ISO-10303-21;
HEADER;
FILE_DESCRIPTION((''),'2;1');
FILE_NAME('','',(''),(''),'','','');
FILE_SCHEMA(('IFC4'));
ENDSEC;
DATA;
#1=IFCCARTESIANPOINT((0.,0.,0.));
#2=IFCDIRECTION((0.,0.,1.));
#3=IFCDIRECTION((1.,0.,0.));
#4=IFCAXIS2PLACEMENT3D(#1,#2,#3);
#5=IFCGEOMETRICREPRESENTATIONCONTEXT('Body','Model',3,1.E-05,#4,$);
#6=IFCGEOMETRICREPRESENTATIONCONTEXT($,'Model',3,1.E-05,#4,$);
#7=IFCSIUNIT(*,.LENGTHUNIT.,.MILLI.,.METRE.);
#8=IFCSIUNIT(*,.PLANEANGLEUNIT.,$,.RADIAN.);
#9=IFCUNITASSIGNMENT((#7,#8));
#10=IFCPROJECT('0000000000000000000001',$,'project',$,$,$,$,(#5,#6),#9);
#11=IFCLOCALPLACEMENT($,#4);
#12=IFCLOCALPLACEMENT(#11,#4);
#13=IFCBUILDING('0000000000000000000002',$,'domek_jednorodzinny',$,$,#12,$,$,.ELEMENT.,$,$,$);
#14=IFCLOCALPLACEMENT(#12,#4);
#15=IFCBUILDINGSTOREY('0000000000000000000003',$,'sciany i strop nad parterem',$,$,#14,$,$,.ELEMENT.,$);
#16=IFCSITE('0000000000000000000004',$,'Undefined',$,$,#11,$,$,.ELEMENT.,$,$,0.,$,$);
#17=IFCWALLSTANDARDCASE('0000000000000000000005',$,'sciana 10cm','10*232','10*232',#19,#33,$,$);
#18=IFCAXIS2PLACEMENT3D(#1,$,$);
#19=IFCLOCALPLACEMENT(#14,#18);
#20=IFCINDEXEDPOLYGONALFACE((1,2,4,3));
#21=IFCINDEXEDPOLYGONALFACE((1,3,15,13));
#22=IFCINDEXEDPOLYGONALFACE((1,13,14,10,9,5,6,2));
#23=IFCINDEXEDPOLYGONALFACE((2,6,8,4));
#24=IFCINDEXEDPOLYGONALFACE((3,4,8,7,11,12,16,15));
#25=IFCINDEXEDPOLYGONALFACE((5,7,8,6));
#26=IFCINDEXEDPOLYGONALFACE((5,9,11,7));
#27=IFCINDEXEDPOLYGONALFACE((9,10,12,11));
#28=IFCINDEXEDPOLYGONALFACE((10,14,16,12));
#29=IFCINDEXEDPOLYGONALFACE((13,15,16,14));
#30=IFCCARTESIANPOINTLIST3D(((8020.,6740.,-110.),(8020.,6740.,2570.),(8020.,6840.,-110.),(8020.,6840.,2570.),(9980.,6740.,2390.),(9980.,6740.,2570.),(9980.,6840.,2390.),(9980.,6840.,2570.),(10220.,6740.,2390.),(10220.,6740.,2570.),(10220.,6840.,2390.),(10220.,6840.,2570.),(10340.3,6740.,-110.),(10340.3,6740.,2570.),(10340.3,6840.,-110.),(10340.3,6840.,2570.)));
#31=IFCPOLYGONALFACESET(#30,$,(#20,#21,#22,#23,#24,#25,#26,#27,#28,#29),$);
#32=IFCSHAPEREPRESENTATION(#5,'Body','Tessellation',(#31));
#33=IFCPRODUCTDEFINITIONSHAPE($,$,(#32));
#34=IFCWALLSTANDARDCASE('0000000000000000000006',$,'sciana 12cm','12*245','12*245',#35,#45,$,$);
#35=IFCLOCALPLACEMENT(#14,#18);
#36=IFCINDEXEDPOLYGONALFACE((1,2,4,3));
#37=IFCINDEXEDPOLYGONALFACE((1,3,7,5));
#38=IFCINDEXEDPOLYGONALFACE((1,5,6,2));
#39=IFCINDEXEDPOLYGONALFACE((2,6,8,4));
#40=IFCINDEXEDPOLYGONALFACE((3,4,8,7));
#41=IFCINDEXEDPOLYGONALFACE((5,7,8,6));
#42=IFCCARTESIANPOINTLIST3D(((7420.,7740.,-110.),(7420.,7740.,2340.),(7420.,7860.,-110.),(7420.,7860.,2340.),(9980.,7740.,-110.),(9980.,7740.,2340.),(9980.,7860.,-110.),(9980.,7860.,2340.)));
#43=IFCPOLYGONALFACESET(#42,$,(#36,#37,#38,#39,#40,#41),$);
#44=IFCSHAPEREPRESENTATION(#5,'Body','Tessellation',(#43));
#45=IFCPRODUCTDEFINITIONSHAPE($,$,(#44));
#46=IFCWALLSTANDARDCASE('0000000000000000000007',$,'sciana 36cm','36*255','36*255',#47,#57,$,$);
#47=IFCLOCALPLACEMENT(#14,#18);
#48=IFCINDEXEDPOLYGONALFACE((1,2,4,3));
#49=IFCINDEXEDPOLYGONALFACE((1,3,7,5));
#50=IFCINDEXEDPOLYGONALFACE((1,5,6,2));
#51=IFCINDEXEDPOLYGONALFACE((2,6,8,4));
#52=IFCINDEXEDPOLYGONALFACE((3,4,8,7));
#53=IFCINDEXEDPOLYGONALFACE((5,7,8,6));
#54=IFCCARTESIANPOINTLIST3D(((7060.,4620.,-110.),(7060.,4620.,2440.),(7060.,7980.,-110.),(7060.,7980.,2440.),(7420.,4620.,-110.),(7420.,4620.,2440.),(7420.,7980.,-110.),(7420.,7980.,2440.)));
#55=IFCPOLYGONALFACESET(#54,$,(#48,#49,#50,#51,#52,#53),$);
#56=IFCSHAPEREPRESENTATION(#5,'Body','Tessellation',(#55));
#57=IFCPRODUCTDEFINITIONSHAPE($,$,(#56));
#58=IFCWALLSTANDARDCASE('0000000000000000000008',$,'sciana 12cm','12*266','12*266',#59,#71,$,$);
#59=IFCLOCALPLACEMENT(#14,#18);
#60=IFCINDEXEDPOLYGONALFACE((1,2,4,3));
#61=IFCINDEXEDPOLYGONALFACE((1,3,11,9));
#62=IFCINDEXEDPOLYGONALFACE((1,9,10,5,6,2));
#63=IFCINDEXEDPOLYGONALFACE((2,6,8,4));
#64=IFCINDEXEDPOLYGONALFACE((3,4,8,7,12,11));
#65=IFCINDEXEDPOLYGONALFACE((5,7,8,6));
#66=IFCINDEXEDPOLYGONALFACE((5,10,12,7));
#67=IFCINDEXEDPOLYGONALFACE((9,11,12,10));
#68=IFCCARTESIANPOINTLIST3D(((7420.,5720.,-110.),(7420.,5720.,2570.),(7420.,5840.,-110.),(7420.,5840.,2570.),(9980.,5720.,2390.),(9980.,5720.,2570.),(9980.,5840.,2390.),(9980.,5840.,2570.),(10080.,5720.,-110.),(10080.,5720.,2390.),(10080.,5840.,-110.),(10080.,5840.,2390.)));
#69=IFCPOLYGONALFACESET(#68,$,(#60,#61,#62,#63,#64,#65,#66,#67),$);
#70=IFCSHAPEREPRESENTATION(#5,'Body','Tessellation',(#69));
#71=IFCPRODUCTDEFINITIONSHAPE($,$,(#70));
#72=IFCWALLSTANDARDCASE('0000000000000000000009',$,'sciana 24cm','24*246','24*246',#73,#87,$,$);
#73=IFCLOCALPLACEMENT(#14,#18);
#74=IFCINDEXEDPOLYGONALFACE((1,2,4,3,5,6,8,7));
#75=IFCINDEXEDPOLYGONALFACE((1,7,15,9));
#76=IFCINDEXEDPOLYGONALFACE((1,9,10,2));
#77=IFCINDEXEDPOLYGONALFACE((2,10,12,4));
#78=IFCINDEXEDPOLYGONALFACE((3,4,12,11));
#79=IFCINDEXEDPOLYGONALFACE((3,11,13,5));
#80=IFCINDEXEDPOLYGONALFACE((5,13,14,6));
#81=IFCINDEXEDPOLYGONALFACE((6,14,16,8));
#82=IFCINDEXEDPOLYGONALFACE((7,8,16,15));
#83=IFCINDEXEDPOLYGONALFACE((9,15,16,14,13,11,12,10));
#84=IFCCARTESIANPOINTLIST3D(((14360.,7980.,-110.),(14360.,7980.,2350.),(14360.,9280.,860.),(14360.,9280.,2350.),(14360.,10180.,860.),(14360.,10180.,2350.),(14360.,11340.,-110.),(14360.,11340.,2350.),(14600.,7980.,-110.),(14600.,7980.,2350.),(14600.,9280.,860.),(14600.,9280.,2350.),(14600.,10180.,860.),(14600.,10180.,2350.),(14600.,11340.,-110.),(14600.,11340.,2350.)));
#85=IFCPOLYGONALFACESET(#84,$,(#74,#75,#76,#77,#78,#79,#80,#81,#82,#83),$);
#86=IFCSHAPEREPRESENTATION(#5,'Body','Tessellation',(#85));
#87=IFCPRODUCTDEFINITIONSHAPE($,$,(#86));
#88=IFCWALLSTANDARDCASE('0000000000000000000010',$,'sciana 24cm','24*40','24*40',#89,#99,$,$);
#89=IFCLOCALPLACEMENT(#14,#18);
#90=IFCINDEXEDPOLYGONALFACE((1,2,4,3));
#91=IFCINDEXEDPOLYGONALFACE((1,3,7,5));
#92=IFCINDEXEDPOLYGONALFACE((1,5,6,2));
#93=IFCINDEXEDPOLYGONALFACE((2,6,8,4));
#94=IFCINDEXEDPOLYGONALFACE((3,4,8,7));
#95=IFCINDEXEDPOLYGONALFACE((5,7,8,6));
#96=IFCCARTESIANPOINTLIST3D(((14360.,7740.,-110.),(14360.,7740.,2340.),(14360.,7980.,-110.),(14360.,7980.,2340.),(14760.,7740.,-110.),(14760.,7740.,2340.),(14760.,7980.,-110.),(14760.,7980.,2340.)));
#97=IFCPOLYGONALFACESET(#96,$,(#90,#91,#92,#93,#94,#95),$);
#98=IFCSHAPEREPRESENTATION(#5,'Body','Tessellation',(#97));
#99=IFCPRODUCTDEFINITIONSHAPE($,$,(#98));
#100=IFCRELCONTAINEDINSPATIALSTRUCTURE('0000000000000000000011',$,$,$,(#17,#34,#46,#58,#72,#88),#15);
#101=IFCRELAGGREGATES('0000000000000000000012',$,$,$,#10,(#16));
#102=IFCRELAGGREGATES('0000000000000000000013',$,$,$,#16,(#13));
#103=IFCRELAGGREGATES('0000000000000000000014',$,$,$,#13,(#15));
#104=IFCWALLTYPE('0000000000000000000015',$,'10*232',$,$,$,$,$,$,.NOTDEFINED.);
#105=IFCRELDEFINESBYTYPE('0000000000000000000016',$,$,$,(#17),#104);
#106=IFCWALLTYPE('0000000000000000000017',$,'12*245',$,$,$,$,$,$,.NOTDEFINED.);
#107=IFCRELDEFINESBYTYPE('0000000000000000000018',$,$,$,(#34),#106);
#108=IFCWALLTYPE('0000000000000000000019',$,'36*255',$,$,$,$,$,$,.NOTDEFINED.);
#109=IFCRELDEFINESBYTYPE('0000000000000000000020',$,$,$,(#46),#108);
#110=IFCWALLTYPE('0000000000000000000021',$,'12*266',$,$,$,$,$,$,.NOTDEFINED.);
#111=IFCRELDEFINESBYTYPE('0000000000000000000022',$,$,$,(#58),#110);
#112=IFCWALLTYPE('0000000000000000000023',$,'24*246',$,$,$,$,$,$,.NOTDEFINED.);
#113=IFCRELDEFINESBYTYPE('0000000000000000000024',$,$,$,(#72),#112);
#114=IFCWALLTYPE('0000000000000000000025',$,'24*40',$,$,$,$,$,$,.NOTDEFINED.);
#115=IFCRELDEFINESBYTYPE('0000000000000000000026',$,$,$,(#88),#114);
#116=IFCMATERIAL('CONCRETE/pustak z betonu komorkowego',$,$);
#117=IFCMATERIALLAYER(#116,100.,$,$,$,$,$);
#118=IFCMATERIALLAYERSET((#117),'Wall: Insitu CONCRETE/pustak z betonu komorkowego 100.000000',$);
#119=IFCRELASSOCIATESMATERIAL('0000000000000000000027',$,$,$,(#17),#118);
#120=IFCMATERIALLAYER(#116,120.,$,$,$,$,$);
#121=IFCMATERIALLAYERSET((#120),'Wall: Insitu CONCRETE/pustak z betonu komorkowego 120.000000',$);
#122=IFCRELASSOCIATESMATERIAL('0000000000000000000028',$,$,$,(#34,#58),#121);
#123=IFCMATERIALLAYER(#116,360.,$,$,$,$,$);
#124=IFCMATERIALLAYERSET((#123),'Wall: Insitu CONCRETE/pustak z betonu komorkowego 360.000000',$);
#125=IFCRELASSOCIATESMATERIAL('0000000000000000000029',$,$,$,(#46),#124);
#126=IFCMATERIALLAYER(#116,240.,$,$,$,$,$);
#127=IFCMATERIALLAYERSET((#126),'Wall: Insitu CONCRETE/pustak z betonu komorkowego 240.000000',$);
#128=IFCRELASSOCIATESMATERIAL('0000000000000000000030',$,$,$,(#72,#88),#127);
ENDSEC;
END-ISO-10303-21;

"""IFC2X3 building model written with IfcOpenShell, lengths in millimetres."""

from ifc_helpers import new_model, si_unit, frame, frame_2d, origin_with_axes, place, context, project, spatial, polyline, rectangle, outline, extrude, material, layer, layer_set, layer_usage, type_object, element, save


model = new_model("IFC2X3")

# Units and contexts
model_context_1 = context("Model", 3, precision=1e-05, world=origin_with_axes(), identifier="Body")
model_context_2 = context("Model", 3, precision=1e-05, world=origin_with_axes())
ifc_project = project(units=[si_unit("LENGTHUNIT", "METRE", prefix="MILLI"), si_unit("PLANEANGLEUNIT", "RADIAN")], contexts=[model_context_1, model_context_2])

# Site, building, storey
site_placement = place(None, origin_with_axes())
site = spatial("IfcSite", under=ifc_project, at=site_placement, Name="Undefined", CompositionType="ELEMENT", RefElevation=0.0)
building_placement = place(site_placement, origin_with_axes())
building = spatial("IfcBuilding", under=site, at=building_placement, Name="domek_jednorodzinny", CompositionType="ELEMENT")
storey_placement = place(building_placement, origin_with_axes())
storey = spatial("IfcBuildingStorey", under=building, at=storey_placement, Name="sciany i strop nad parterem", CompositionType="ELEMENT")

# Wall, opening
ifc_material_1 = material(Name="CONCRETE/pustak z betonu komorkowego")
ifc_layer_1 = layer(ifc_material_1, 100.0)
ifc_layer_set_1 = layer_set([ifc_layer_1], Name="Wall: Insitu CONCRETE/pustak z betonu komorkowego 100.000000")
ifc_layer_usage_1 = layer_usage(ifc_layer_set_1, "AXIS2", "POSITIVE", -50.0)
wall_type_1 = type_object("IfcWallType", Name="10*232", PredefinedType="NOTDEFINED")
wall_1_placement = place(storey_placement, frame((10340.3, 6790.0, -110.0), z_axis=(0.0, 0.0, 1.0), x_axis=(-1.0, 0.0, 0.0)))
wall_1 = element("IfcWallStandardCase", 1, at=wall_1_placement, inside=storey, type_object=wall_type_1, material=ifc_layer_usage_1, Name="sciana 10cm", Description="10*232", ObjectType="10*232", context=model_context_1, shape_type="SweptSolid", body=[
    extrude(rectangle(XDim=2320.3, YDim=100.0, at=frame_2d((0.0, 1160.1), x_axis=(0.0, -1.0))), frame((0.0, 0.0, 0.0), z_axis=(0.0, 0.0, 1.0), x_axis=(0.0, -1.0, 0.0)), (0.0, 0.0, 1.0), 2680.0),
])
opening_1_placement = place(storey_placement, frame((10340.3, 6790.0, -110.0), z_axis=(0.0, 0.0, 1.0), x_axis=(-1.0, 0.0, 0.0)))
element("IfcOpeningElement", 2, at=opening_1_placement, cuts=wall_1, ObjectType="Recess", context=model_context_1, shape_type="SweptSolid", body=[
    extrude(outline(polyline([(0.0, 0.0), (180.0, 0.0), (180.0, 240.0), (0.0, 240.0), (0.0, 0.0)])), frame((360.3, -52.5, 2680.0), z_axis=(0.0, 1.0, 0.0), x_axis=(0.000001, 0.000001, -1.0)), (0.0, 0.0, 1.0), 105.0),
])

# Walls
ifc_layer_2 = layer(ifc_material_1, 120.0)
ifc_layer_set_2 = layer_set([ifc_layer_2], Name="Wall: Insitu CONCRETE/pustak z betonu komorkowego 120.000000")
ifc_layer_usage_2 = layer_usage(ifc_layer_set_2, "AXIS2", "POSITIVE", -60.0)
wall_type_2 = type_object("IfcWallType", Name="12*245", PredefinedType="NOTDEFINED")
wall_2_placement = place(storey_placement, frame((7420.0, 7800.0, -110.0), z_axis=(0.0, 0.0, 1.0), x_axis=(1.0, 0.0, 0.0)))
element("IfcWallStandardCase", 3, at=wall_2_placement, inside=storey, type_object=wall_type_2, material=ifc_layer_usage_2, Name="sciana 12cm", Description="12*245", ObjectType="12*245", context=model_context_1, shape_type="SweptSolid", body=[
    extrude(rectangle(XDim=2560.0, YDim=120.0, at=frame_2d((0.0, 1280.0), x_axis=(0.0, -1.0))), frame((0.0, 0.0, 0.0), z_axis=(0.0, 0.0, 1.0), x_axis=(0.0, -1.0, 0.0)), (0.0, 0.0, 1.0), 2450.0),
])
ifc_layer_3 = layer(ifc_material_1, 360.0)
ifc_layer_set_3 = layer_set([ifc_layer_3], Name="Wall: Insitu CONCRETE/pustak z betonu komorkowego 360.000000")
ifc_layer_usage_3 = layer_usage(ifc_layer_set_3, "AXIS2", "POSITIVE", -180.0)
wall_type_3 = type_object("IfcWallType", Name="36*255", PredefinedType="NOTDEFINED")
wall_3_placement = place(storey_placement, frame((7240.0, 4620.0, -110.0), z_axis=(0.0, 0.0, 1.0), x_axis=(0.0, 1.0, 0.0)))
element("IfcWallStandardCase", 4, at=wall_3_placement, inside=storey, type_object=wall_type_3, material=ifc_layer_usage_3, Name="sciana 36cm", Description="36*255", ObjectType="36*255", context=model_context_1, shape_type="SweptSolid", body=[
    extrude(rectangle(XDim=3360.0, YDim=360.0, at=frame_2d((0.0, 1680.0), x_axis=(0.0, -1.0))), frame((0.0, 0.0, 0.0), z_axis=(0.0, 0.0, 1.0), x_axis=(0.0, -1.0, 0.0)), (0.0, 0.0, 1.0), 2550.0),
])

# Walls, openings
ifc_layer_usage_4 = layer_usage(ifc_layer_set_2, "AXIS2", "POSITIVE", -60.0)
wall_type_4 = type_object("IfcWallType", Name="12*266", PredefinedType="NOTDEFINED")
wall_4_placement = place(storey_placement, frame((7420.0, 5780.0, -110.0), z_axis=(0.0, 0.0, 1.0), x_axis=(1.0, 0.0, 0.0)))
wall_4 = element("IfcWallStandardCase", 5, at=wall_4_placement, inside=storey, type_object=wall_type_4, material=ifc_layer_usage_4, Name="sciana 12cm", Description="12*266", ObjectType="12*266", context=model_context_1, shape_type="SweptSolid", body=[
    extrude(rectangle(XDim=2660.0, YDim=120.0, at=frame_2d((0.0, 1330.0), x_axis=(0.0, -1.0))), frame((0.0, 0.0, 0.0), z_axis=(0.0, 0.0, 1.0), x_axis=(0.0, -1.0, 0.0)), (0.0, 0.0, 1.0), 2680.0),
])
opening_2_placement = place(storey_placement, frame((7420.0, 5780.0, -110.0), z_axis=(0.0, 0.0, 1.0), x_axis=(1.0, 0.0, 0.0)))
element("IfcOpeningElement", 6, at=opening_2_placement, cuts=wall_4, ObjectType="Recess", context=model_context_1, shape_type="SweptSolid", body=[
    extrude(outline(polyline([(0.0, 0.0), (180.0, 0.0), (180.0, 240.0), (0.0, 240.0), (0.0, 0.0)])), frame((2800.0, -63.0, 2680.0), z_axis=(-0.000017, 1.0, 0.0), x_axis=(-0.000196, 0.0, -1.0)), (0.0, 0.0, 1.0), 126.0),
])
ifc_layer_4 = layer(ifc_material_1, 240.0)
ifc_layer_set_4 = layer_set([ifc_layer_4], Name="Wall: Insitu CONCRETE/pustak z betonu komorkowego 240.000000")
ifc_layer_usage_5 = layer_usage(ifc_layer_set_4, "AXIS2", "POSITIVE", -120.0)
wall_type_5 = type_object("IfcWallType", Name="24*246", PredefinedType="NOTDEFINED")
wall_5_placement = place(storey_placement, frame((14480.0, 7980.0, -110.0), z_axis=(0.0, 0.0, 1.0), x_axis=(0.0, 1.0, 0.0)))
wall_5 = element("IfcWallStandardCase", 7, at=wall_5_placement, inside=storey, type_object=wall_type_5, material=ifc_layer_usage_5, Name="sciana 24cm", Description="24*246", ObjectType="24*246", context=model_context_1, shape_type="SweptSolid", body=[
    extrude(rectangle(XDim=3360.0, YDim=240.0, at=frame_2d((0.0, 1680.0), x_axis=(0.0, -1.0))), frame((0.0, 0.0, 0.0), z_axis=(0.0, 0.0, 1.0), x_axis=(0.0, -1.0, 0.0)), (0.0, 0.0, 1.0), 2460.0),
])
opening_3_placement = place(storey_placement, frame((14480.0, 7980.0, -110.0), z_axis=(0.0, 0.0, 1.0), x_axis=(0.0, 1.0, 0.0)))
element("IfcOpeningElement", 8, at=opening_3_placement, cuts=wall_5, ObjectType="Recess", context=model_context_1, shape_type="SweptSolid", body=[
    extrude(outline(polyline([(0.0, 0.0), (329.9, 0.0), (319.9, 900.0), (-0.1, 900.0), (0.0, 0.0)])), frame((1300.0, -160.0, 2470.0), z_axis=(0.000001, 0.000001, -1.0), x_axis=(0.0, 1.0, 0.0)), (0.0, 0.0, 1.0), 1500.0),
])

# Wall
ifc_layer_usage_6 = layer_usage(ifc_layer_set_4, "AXIS2", "POSITIVE", -120.0)
wall_type_6 = type_object("IfcWallType", Name="24*40", PredefinedType="NOTDEFINED")
wall_6_placement = place(storey_placement, frame((14360.0, 7860.0, -110.0), z_axis=(0.0, 0.0, 1.0), x_axis=(1.0, 0.0, 0.0)))
element("IfcWallStandardCase", 9, at=wall_6_placement, inside=storey, type_object=wall_type_6, material=ifc_layer_usage_6, Name="sciana 24cm", Description="24*40", ObjectType="24*40", context=model_context_1, shape_type="SweptSolid", body=[
    extrude(rectangle(XDim=400.0, YDim=240.0, at=frame_2d((0.0, 200.0), x_axis=(0.0, -1.0))), frame((0.0, 0.0, 0.0), z_axis=(0.0, 0.0, 1.0), x_axis=(0.0, -1.0, 0.0)), (0.0, 0.0, 1.0), 2450.0),
])

save(model, "model.ifc")
